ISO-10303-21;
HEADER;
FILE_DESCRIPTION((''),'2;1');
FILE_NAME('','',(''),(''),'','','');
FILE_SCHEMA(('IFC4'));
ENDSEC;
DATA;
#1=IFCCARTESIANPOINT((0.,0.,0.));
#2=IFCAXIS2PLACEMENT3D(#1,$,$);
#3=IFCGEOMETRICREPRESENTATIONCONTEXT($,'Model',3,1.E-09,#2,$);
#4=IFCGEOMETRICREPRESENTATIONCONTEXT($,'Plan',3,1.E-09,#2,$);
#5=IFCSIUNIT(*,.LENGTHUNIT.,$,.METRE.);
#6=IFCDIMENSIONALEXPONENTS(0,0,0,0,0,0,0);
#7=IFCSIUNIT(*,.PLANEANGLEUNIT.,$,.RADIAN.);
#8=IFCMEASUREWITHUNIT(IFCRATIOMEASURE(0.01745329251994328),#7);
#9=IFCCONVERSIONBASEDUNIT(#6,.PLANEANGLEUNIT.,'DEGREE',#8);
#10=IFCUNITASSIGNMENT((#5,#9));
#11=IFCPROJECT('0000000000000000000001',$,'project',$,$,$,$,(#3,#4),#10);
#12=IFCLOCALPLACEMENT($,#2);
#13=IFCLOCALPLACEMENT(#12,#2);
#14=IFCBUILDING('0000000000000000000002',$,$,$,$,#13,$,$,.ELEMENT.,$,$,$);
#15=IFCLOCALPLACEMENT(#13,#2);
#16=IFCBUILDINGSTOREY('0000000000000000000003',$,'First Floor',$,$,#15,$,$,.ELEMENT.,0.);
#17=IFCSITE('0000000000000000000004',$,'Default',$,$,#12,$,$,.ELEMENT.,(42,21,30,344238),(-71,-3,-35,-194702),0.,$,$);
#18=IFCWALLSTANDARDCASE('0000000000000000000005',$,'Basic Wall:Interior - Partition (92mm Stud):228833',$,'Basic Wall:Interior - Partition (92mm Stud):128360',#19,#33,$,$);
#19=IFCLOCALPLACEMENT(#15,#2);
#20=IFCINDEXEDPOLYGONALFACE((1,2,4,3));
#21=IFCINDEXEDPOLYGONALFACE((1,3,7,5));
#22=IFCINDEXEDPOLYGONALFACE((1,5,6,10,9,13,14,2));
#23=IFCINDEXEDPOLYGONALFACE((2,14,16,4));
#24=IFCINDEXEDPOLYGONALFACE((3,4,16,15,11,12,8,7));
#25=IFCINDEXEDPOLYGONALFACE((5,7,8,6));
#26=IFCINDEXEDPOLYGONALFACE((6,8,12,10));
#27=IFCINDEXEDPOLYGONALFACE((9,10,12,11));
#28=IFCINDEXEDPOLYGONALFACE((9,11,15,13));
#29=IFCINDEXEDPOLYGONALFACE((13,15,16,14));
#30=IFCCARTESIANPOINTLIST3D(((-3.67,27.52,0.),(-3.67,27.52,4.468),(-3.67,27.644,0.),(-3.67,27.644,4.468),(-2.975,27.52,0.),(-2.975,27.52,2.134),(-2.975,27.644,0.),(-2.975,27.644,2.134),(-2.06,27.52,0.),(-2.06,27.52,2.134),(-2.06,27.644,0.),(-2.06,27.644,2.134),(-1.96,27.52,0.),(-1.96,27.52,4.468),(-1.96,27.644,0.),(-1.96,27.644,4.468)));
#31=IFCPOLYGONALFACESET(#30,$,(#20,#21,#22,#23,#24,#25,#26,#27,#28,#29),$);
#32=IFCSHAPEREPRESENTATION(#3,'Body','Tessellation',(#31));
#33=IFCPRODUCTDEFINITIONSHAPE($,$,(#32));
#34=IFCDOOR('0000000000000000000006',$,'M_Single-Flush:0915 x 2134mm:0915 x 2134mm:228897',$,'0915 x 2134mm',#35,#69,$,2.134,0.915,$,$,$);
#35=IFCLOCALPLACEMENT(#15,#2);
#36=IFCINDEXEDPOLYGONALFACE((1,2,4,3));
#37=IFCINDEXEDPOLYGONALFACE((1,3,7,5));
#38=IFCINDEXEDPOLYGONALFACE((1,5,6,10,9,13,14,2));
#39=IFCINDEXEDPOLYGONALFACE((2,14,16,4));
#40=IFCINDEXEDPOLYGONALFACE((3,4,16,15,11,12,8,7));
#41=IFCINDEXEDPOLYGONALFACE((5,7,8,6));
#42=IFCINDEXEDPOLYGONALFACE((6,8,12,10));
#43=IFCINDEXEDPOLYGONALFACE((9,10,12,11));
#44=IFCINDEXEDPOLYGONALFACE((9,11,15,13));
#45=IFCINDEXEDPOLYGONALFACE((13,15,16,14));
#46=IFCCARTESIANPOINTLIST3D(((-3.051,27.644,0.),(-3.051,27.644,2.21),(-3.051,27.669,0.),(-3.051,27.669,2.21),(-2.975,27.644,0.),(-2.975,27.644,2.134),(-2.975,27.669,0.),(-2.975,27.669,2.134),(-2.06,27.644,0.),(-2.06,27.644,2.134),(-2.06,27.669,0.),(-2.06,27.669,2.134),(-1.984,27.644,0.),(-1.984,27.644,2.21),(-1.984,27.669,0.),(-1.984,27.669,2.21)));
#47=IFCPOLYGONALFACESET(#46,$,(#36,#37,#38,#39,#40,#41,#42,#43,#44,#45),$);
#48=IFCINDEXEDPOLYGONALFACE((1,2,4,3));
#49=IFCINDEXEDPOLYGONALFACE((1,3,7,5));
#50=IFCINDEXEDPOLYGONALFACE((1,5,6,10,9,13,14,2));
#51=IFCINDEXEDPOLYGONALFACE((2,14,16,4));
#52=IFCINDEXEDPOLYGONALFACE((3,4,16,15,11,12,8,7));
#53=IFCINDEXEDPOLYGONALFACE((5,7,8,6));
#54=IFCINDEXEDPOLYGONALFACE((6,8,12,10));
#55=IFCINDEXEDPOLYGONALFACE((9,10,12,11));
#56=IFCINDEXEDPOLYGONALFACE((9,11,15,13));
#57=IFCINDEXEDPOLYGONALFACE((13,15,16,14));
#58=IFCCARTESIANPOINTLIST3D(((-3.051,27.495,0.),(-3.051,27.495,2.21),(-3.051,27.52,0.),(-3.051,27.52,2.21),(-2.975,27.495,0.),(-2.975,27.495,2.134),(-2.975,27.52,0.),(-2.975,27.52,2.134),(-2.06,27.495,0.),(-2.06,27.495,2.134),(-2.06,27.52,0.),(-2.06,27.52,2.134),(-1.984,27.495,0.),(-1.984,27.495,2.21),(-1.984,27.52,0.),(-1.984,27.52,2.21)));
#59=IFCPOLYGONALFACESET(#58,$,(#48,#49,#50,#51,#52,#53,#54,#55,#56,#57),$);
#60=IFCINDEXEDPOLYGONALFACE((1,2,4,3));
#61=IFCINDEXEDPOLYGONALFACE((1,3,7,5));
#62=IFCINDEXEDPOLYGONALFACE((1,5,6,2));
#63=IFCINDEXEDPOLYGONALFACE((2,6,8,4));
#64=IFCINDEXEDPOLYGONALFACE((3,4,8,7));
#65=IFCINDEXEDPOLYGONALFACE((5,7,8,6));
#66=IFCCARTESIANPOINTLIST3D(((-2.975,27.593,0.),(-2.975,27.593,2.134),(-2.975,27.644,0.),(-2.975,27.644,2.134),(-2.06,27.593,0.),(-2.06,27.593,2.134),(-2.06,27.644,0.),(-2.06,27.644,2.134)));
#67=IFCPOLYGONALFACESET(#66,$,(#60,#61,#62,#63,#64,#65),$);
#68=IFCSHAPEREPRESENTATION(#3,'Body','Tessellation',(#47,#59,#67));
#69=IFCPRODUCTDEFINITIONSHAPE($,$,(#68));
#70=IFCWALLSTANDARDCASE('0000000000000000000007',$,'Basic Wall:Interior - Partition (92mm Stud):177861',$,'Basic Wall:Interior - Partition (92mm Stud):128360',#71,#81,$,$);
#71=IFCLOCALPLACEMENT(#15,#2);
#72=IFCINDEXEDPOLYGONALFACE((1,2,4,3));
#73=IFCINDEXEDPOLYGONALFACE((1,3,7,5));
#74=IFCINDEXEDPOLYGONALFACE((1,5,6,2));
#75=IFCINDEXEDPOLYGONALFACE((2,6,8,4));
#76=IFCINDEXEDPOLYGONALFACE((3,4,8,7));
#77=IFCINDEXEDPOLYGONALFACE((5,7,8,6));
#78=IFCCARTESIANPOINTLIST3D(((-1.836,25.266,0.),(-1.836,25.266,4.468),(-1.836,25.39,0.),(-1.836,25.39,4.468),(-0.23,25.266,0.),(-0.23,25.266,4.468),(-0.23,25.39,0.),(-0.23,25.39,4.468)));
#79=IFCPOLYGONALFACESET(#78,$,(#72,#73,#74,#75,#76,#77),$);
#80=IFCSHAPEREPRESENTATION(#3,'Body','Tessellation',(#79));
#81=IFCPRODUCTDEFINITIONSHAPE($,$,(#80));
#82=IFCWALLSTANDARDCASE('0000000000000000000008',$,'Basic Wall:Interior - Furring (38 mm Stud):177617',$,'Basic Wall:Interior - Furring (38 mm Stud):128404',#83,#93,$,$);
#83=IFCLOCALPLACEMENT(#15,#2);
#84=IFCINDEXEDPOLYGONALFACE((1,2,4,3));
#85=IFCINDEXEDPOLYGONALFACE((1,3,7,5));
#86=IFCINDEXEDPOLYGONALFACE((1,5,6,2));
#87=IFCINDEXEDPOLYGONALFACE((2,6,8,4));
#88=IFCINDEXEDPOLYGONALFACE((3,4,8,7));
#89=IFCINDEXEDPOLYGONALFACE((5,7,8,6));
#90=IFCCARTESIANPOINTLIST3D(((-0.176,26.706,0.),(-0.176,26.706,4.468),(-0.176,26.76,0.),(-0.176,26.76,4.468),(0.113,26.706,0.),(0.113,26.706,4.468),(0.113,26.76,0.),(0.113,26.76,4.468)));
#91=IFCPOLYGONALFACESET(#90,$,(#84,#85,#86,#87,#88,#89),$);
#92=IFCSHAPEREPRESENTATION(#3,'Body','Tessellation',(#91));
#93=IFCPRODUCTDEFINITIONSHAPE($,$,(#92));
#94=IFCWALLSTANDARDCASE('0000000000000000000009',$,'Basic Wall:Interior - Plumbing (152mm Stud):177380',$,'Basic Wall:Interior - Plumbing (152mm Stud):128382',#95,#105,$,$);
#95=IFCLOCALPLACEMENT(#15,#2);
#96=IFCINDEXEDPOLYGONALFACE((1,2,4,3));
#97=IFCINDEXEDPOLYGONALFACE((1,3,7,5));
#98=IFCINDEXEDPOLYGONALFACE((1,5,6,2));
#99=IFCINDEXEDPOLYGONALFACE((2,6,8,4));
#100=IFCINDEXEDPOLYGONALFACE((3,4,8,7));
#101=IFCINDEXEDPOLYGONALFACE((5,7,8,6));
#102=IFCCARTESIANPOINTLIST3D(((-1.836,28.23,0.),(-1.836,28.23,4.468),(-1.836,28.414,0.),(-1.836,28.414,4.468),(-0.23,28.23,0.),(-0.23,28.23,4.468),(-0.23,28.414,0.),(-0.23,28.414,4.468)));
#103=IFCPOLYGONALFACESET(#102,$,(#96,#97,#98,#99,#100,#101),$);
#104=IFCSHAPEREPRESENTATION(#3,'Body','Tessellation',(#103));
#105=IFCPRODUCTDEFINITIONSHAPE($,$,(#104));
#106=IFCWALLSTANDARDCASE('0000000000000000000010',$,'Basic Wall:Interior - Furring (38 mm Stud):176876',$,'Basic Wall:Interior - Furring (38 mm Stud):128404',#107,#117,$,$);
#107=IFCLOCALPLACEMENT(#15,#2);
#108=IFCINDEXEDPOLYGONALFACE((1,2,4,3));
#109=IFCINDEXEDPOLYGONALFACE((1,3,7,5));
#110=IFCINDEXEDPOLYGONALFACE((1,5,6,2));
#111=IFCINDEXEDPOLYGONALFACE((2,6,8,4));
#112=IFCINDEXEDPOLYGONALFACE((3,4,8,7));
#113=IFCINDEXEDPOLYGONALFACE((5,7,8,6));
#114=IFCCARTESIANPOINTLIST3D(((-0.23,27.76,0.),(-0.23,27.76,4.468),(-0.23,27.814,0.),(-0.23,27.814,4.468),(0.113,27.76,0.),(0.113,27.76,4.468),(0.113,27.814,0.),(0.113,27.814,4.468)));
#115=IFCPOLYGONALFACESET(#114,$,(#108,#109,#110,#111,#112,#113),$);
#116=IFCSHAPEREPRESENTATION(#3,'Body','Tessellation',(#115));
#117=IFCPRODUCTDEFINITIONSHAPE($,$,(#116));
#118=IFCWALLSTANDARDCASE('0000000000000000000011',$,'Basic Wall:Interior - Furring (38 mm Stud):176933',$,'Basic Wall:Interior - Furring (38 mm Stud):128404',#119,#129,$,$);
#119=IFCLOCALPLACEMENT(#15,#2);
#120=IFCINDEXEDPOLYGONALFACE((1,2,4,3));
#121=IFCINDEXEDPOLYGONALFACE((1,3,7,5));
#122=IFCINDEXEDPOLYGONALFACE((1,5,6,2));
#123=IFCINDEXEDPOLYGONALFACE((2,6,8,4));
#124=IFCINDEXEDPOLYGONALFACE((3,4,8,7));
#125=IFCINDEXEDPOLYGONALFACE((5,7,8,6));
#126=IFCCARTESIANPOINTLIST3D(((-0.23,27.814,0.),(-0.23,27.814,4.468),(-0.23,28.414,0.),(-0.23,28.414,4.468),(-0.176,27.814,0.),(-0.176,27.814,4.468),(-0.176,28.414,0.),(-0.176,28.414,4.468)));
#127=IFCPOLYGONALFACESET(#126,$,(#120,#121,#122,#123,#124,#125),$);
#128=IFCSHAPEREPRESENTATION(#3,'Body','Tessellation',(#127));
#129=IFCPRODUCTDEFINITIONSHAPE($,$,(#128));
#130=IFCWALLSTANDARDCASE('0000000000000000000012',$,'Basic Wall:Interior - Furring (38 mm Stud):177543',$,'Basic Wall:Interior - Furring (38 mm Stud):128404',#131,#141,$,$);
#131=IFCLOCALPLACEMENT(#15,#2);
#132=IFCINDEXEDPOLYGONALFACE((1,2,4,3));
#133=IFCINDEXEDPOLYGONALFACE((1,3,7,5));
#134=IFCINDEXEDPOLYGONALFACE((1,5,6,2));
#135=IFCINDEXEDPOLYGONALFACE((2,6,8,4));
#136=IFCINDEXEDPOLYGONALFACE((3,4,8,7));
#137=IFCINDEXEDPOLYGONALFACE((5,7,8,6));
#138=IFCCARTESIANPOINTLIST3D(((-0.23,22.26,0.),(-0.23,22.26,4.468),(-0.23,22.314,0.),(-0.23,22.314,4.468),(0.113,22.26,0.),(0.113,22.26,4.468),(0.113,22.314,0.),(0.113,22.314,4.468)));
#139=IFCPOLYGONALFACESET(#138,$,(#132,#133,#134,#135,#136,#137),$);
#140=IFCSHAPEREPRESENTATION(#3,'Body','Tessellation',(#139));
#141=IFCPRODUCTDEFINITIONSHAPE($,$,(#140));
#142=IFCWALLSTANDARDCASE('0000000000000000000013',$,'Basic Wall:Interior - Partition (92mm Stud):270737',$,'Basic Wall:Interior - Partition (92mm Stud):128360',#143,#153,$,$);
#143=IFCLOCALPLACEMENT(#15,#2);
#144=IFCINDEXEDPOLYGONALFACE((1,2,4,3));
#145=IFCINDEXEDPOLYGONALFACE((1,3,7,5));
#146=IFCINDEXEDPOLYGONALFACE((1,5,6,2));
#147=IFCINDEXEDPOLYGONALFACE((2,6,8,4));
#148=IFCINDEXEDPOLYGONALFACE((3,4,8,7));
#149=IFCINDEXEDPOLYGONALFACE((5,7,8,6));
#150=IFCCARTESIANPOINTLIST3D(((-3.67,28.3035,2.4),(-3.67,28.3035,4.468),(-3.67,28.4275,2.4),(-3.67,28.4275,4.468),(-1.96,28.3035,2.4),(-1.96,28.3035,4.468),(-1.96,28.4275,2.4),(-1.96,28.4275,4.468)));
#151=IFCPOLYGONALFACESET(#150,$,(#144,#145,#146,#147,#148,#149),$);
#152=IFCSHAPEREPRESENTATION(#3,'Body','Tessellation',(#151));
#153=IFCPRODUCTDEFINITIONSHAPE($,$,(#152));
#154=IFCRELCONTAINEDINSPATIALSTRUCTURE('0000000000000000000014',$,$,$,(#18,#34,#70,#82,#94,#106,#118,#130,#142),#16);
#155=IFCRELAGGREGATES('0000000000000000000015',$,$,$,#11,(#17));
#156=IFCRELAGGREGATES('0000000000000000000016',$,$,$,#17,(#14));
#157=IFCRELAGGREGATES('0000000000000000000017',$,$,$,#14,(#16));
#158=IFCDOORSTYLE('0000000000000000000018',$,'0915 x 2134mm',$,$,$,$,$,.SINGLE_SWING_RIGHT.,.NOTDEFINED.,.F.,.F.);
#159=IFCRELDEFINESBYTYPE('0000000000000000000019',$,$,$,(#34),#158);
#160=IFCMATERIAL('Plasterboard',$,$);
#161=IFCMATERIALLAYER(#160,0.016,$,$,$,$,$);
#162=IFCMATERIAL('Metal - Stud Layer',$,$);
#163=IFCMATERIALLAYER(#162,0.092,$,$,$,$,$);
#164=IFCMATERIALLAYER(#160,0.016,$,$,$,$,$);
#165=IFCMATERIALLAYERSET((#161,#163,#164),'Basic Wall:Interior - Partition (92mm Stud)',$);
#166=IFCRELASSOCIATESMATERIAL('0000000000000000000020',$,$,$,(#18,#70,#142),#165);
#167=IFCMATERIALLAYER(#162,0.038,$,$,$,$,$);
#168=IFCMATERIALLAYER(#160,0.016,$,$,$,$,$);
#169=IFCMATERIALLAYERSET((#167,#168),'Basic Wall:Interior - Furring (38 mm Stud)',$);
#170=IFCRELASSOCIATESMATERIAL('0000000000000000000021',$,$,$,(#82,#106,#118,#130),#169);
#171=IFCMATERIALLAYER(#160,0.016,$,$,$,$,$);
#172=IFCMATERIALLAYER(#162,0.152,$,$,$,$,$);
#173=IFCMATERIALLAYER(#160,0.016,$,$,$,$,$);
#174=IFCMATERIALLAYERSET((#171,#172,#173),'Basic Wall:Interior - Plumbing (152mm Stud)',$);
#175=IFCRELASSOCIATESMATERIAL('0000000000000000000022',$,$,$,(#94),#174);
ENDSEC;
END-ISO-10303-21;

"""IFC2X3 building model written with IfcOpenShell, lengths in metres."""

from ifc_helpers import new_model, entity, si_unit, converted_unit, frame, frame_2d, origin, origin_2d_with_axis, place, context, project, spatial, polyline, rectangle, outline, extrude, source, transform, mapped, material, layer, layer_set, layer_usage, type_object, type_shapes, element, fill, save


model = new_model("IFC2X3")

# Units and contexts
model_context = context("Model", 3, precision=1e-09, world=origin())
plan_context = context("Plan", 3, precision=1e-09, world=origin())
ifc_project = project(units=[si_unit("LENGTHUNIT", "METRE"), converted_unit("PLANEANGLEUNIT", "DEGREE", entity("IfcRatioMeasure", 0.01745329251994328), si_unit("PLANEANGLEUNIT", "RADIAN"), dimensions=[0, 0, 0, 0, 0, 0, 0])], contexts=[model_context, plan_context])

# Site, building, storey
site_placement = place(None, origin())
site = spatial("IfcSite", under=ifc_project, at=site_placement, Name="Default", CompositionType="ELEMENT", RefLatitude=(42, 21, 30, 344238), RefLongitude=(-71, -3, -35, -194702), RefElevation=0.0)
building_placement = place(site_placement, origin())
building = spatial("IfcBuilding", under=site, at=building_placement, CompositionType="ELEMENT")
storey_placement = place(building_placement, origin())
storey = spatial("IfcBuildingStorey", under=building, at=storey_placement, Name="First Floor", CompositionType="ELEMENT", Elevation=0.0)

# Shared definitions
ifc_material_1 = material(Name="Plasterboard")
ifc_layer_1 = layer(ifc_material_1, 0.016)
ifc_material_2 = material(Name="Metal - Stud Layer")
ifc_layer_2 = layer(ifc_material_2, 0.092)
ifc_layer_3 = layer(ifc_material_1, 0.016)
ifc_layer_set_1 = layer_set([ifc_layer_1, ifc_layer_2, ifc_layer_3], Name="Basic Wall:Interior - Partition (92mm Stud)")
ifc_layer_usage_1 = layer_usage(ifc_layer_set_1, "AXIS2", "NEGATIVE", 0.062)
door_style = type_object("IfcDoorStyle", Name="0915 x 2134mm", ConstructionType="NOTDEFINED", OperationType="SINGLE_SWING_RIGHT", ParameterTakesPrecedence=False, Sizeable=False)
shared_shape_1 = source(origin(), model_context, "Body", "SweptSolid", [
    extrude(outline(polyline([(-0.5335, -1.124), (0.5335, -1.124), (0.5335, 1.086), (0.4575, 1.086), (0.4575, -1.048), (-0.4575, -1.048), (-0.4575, 1.086), (-0.5335, 1.086), (-0.5335, -1.124)])), frame((0.4575, 0.124, 1.086), z_axis=(0.0, 1.0, 0.0), x_axis=(1.0, 0.0, 0.0)), (0.0, 0.0, 1.0), 0.025),
    extrude(outline(polyline([(-1.124, -0.5335), (1.086, -0.5335), (1.086, -0.4575), (-1.048, -0.4575), (-1.048, 0.4575), (1.086, 0.4575), (1.086, 0.5335), (-1.124, 0.5335), (-1.124, -0.5335)])), frame((0.4575, -0.025, 1.086), z_axis=(0.0, 1.0, 0.0), x_axis=(0.0, 0.0, -1.0)), (0.0, 0.0, 1.0), 0.025),
    extrude(rectangle(XDim=0.051, YDim=0.915, at=origin_2d_with_axis()), frame((0.4575, 0.0985, 0.0), z_axis=(0.0, 0.0, 1.0), x_axis=(0.0, 1.0, 0.0)), (0.0, 0.0, 1.0), 2.134),
])
type_shapes(door_style, [shared_shape_1])

# Shared definitions
ifc_layer_4 = layer(ifc_material_2, 0.038)
ifc_layer_5 = layer(ifc_material_1, 0.016)
ifc_layer_set_2 = layer_set([ifc_layer_4, ifc_layer_5], Name="Basic Wall:Interior - Furring (38 mm Stud)")
ifc_layer_usage_2 = layer_usage(ifc_layer_set_2, "AXIS2", "POSITIVE", -0.027)

# Wall, opening, door
wall_1_placement = place(storey_placement, frame((-1.96, 27.582, 0.0), z_axis=(0.0, 0.0, 1.0), x_axis=(-1.0, 0.0, 0.0)))
wall_1 = element("IfcWallStandardCase", 1, at=wall_1_placement, inside=storey, material=ifc_layer_usage_1, Name="Basic Wall:Interior - Partition (92mm Stud):228833", ObjectType="Basic Wall:Interior - Partition (92mm Stud):128360", context=model_context, shape_type="SweptSolid", body=[
    extrude(rectangle(XDim=1.71, YDim=0.124, at=frame_2d((0.855, 0.0), x_axis=(-1.0, 0.0))), origin(), (0.0, 0.0, 1.0), 4.468),
])
opening_1_placement = place(wall_1_placement, frame((1.015, 0.062, 0.0)))
opening_1 = element("IfcOpeningElement", 2, at=opening_1_placement, cuts=wall_1, ObjectType="Opening", context=model_context, shape_type="SweptSolid", body=[
    extrude(rectangle(XDim=0.915, YDim=2.134, at=frame_2d((1.067, 0.4575), x_axis=(0.0, 1.0))), frame((0.0, 0.0, 0.0), z_axis=(0.0, -1.0, 0.0), x_axis=(0.0, 0.0, 1.0)), (0.0, 0.0, 1.0), 0.124),
])
door_1_placement = place(opening_1_placement, frame((0.0, 0.0, 0.0), z_axis=(0.0, 0.0, 1.0), x_axis=(-1.0, 0.0, 0.0)))
door_1 = element("IfcDoor", 3, at=door_1_placement, inside=storey, type_object=door_style, Name="M_Single-Flush:0915 x 2134mm:0915 x 2134mm:228897", ObjectType="0915 x 2134mm", OverallHeight=2.134, OverallWidth=0.915, context=model_context, shape_type="MappedRepresentation", body=[
    mapped(shared_shape_1, transform((0.0, 0.0, 0.0), scale=1.0)),
])
fill(opening_1, door_1)

# Walls
wall_2_placement = place(storey_placement, frame((-1.836, 25.328, 0.0)))
element("IfcWallStandardCase", 4, at=wall_2_placement, inside=storey, material=ifc_layer_usage_1, Name="Basic Wall:Interior - Partition (92mm Stud):177861", ObjectType="Basic Wall:Interior - Partition (92mm Stud):128360", context=model_context, shape_type="SweptSolid", body=[
    extrude(rectangle(XDim=1.606, YDim=0.124, at=frame_2d((0.803, 0.0), x_axis=(-1.0, 0.0))), origin(), (0.0, 0.0, 1.0), 4.468),
])
wall_3_placement = place(storey_placement, frame((-0.176, 26.733, 0.0)))
element("IfcWallStandardCase", 5, at=wall_3_placement, inside=storey, material=ifc_layer_usage_2, Name="Basic Wall:Interior - Furring (38 mm Stud):177617", ObjectType="Basic Wall:Interior - Furring (38 mm Stud):128404", context=model_context, shape_type="SweptSolid", body=[
    extrude(rectangle(XDim=0.289, YDim=0.054, at=frame_2d((0.1445, 0.0), x_axis=(-1.0, 0.0))), origin(), (0.0, 0.0, 1.0), 4.468),
])
ifc_layer_6 = layer(ifc_material_1, 0.016)
ifc_layer_7 = layer(ifc_material_2, 0.152)
ifc_layer_8 = layer(ifc_material_1, 0.016)
ifc_layer_set_3 = layer_set([ifc_layer_6, ifc_layer_7, ifc_layer_8], Name="Basic Wall:Interior - Plumbing (152mm Stud)")
ifc_layer_usage_3 = layer_usage(ifc_layer_set_3, "AXIS2", "NEGATIVE", 0.092)
wall_4_placement = place(storey_placement, frame((-0.23, 28.322, 0.0), z_axis=(0.0, 0.0, 1.0), x_axis=(-1.0, 0.0, 0.0)))
element("IfcWallStandardCase", 6, at=wall_4_placement, inside=storey, material=ifc_layer_usage_3, Name="Basic Wall:Interior - Plumbing (152mm Stud):177380", ObjectType="Basic Wall:Interior - Plumbing (152mm Stud):128382", context=model_context, shape_type="SweptSolid", body=[
    extrude(rectangle(XDim=1.606, YDim=0.184, at=frame_2d((0.803, 0.0), x_axis=(-1.0, 0.0))), origin(), (0.0, 0.0, 1.0), 4.468),
])
wall_5_placement = place(storey_placement, frame((0.113, 27.787, 0.0), z_axis=(0.0, 0.0, 1.0), x_axis=(-1.0, 0.0, 0.0)))
element("IfcWallStandardCase", 7, at=wall_5_placement, inside=storey, material=ifc_layer_usage_2, Name="Basic Wall:Interior - Furring (38 mm Stud):176876", ObjectType="Basic Wall:Interior - Furring (38 mm Stud):128404", context=model_context, shape_type="SweptSolid", body=[
    extrude(rectangle(XDim=0.343, YDim=0.054, at=frame_2d((0.1715, 0.0), x_axis=(-1.0, 0.0))), origin(), (0.0, 0.0, 1.0), 4.468),
])
wall_6_placement = place(storey_placement, frame((-0.203, 27.814, 0.0), z_axis=(0.0, 0.0, 1.0), x_axis=(0.0, 1.0, 0.0)))
element("IfcWallStandardCase", 8, at=wall_6_placement, inside=storey, material=ifc_layer_usage_2, Name="Basic Wall:Interior - Furring (38 mm Stud):176933", ObjectType="Basic Wall:Interior - Furring (38 mm Stud):128404", context=model_context, shape_type="SweptSolid", body=[
    extrude(rectangle(XDim=0.6, YDim=0.054, at=frame_2d((0.3, 0.0), x_axis=(-1.0, 0.0))), origin(), (0.0, 0.0, 1.0), 4.468),
])
wall_7_placement = place(storey_placement, frame((0.113, 22.287, 0.0), z_axis=(0.0, 0.0, 1.0), x_axis=(-1.0, 0.0, 0.0)))
element("IfcWallStandardCase", 9, at=wall_7_placement, inside=storey, material=ifc_layer_usage_2, Name="Basic Wall:Interior - Furring (38 mm Stud):177543", ObjectType="Basic Wall:Interior - Furring (38 mm Stud):128404", context=model_context, shape_type="SweptSolid", body=[
    extrude(rectangle(XDim=0.343, YDim=0.054, at=frame_2d((0.1715, 0.0), x_axis=(-1.0, 0.0))), origin(), (0.0, 0.0, 1.0), 4.468),
])
wall_8_placement = place(storey_placement, frame((-1.96, 28.3655, 2.4), z_axis=(0.0, 0.0, 1.0), x_axis=(-1.0, 0.0, 0.0)))
element("IfcWallStandardCase", 10, at=wall_8_placement, inside=storey, material=ifc_layer_usage_1, Name="Basic Wall:Interior - Partition (92mm Stud):270737", ObjectType="Basic Wall:Interior - Partition (92mm Stud):128360", context=model_context, shape_type="SweptSolid", body=[
    extrude(rectangle(XDim=1.71, YDim=0.124, at=frame_2d((0.855, 0.0), x_axis=(-1.0, 0.0))), origin(), (0.0, 0.0, 1.0), 2.068),
])

save(model, "model.ifc")
